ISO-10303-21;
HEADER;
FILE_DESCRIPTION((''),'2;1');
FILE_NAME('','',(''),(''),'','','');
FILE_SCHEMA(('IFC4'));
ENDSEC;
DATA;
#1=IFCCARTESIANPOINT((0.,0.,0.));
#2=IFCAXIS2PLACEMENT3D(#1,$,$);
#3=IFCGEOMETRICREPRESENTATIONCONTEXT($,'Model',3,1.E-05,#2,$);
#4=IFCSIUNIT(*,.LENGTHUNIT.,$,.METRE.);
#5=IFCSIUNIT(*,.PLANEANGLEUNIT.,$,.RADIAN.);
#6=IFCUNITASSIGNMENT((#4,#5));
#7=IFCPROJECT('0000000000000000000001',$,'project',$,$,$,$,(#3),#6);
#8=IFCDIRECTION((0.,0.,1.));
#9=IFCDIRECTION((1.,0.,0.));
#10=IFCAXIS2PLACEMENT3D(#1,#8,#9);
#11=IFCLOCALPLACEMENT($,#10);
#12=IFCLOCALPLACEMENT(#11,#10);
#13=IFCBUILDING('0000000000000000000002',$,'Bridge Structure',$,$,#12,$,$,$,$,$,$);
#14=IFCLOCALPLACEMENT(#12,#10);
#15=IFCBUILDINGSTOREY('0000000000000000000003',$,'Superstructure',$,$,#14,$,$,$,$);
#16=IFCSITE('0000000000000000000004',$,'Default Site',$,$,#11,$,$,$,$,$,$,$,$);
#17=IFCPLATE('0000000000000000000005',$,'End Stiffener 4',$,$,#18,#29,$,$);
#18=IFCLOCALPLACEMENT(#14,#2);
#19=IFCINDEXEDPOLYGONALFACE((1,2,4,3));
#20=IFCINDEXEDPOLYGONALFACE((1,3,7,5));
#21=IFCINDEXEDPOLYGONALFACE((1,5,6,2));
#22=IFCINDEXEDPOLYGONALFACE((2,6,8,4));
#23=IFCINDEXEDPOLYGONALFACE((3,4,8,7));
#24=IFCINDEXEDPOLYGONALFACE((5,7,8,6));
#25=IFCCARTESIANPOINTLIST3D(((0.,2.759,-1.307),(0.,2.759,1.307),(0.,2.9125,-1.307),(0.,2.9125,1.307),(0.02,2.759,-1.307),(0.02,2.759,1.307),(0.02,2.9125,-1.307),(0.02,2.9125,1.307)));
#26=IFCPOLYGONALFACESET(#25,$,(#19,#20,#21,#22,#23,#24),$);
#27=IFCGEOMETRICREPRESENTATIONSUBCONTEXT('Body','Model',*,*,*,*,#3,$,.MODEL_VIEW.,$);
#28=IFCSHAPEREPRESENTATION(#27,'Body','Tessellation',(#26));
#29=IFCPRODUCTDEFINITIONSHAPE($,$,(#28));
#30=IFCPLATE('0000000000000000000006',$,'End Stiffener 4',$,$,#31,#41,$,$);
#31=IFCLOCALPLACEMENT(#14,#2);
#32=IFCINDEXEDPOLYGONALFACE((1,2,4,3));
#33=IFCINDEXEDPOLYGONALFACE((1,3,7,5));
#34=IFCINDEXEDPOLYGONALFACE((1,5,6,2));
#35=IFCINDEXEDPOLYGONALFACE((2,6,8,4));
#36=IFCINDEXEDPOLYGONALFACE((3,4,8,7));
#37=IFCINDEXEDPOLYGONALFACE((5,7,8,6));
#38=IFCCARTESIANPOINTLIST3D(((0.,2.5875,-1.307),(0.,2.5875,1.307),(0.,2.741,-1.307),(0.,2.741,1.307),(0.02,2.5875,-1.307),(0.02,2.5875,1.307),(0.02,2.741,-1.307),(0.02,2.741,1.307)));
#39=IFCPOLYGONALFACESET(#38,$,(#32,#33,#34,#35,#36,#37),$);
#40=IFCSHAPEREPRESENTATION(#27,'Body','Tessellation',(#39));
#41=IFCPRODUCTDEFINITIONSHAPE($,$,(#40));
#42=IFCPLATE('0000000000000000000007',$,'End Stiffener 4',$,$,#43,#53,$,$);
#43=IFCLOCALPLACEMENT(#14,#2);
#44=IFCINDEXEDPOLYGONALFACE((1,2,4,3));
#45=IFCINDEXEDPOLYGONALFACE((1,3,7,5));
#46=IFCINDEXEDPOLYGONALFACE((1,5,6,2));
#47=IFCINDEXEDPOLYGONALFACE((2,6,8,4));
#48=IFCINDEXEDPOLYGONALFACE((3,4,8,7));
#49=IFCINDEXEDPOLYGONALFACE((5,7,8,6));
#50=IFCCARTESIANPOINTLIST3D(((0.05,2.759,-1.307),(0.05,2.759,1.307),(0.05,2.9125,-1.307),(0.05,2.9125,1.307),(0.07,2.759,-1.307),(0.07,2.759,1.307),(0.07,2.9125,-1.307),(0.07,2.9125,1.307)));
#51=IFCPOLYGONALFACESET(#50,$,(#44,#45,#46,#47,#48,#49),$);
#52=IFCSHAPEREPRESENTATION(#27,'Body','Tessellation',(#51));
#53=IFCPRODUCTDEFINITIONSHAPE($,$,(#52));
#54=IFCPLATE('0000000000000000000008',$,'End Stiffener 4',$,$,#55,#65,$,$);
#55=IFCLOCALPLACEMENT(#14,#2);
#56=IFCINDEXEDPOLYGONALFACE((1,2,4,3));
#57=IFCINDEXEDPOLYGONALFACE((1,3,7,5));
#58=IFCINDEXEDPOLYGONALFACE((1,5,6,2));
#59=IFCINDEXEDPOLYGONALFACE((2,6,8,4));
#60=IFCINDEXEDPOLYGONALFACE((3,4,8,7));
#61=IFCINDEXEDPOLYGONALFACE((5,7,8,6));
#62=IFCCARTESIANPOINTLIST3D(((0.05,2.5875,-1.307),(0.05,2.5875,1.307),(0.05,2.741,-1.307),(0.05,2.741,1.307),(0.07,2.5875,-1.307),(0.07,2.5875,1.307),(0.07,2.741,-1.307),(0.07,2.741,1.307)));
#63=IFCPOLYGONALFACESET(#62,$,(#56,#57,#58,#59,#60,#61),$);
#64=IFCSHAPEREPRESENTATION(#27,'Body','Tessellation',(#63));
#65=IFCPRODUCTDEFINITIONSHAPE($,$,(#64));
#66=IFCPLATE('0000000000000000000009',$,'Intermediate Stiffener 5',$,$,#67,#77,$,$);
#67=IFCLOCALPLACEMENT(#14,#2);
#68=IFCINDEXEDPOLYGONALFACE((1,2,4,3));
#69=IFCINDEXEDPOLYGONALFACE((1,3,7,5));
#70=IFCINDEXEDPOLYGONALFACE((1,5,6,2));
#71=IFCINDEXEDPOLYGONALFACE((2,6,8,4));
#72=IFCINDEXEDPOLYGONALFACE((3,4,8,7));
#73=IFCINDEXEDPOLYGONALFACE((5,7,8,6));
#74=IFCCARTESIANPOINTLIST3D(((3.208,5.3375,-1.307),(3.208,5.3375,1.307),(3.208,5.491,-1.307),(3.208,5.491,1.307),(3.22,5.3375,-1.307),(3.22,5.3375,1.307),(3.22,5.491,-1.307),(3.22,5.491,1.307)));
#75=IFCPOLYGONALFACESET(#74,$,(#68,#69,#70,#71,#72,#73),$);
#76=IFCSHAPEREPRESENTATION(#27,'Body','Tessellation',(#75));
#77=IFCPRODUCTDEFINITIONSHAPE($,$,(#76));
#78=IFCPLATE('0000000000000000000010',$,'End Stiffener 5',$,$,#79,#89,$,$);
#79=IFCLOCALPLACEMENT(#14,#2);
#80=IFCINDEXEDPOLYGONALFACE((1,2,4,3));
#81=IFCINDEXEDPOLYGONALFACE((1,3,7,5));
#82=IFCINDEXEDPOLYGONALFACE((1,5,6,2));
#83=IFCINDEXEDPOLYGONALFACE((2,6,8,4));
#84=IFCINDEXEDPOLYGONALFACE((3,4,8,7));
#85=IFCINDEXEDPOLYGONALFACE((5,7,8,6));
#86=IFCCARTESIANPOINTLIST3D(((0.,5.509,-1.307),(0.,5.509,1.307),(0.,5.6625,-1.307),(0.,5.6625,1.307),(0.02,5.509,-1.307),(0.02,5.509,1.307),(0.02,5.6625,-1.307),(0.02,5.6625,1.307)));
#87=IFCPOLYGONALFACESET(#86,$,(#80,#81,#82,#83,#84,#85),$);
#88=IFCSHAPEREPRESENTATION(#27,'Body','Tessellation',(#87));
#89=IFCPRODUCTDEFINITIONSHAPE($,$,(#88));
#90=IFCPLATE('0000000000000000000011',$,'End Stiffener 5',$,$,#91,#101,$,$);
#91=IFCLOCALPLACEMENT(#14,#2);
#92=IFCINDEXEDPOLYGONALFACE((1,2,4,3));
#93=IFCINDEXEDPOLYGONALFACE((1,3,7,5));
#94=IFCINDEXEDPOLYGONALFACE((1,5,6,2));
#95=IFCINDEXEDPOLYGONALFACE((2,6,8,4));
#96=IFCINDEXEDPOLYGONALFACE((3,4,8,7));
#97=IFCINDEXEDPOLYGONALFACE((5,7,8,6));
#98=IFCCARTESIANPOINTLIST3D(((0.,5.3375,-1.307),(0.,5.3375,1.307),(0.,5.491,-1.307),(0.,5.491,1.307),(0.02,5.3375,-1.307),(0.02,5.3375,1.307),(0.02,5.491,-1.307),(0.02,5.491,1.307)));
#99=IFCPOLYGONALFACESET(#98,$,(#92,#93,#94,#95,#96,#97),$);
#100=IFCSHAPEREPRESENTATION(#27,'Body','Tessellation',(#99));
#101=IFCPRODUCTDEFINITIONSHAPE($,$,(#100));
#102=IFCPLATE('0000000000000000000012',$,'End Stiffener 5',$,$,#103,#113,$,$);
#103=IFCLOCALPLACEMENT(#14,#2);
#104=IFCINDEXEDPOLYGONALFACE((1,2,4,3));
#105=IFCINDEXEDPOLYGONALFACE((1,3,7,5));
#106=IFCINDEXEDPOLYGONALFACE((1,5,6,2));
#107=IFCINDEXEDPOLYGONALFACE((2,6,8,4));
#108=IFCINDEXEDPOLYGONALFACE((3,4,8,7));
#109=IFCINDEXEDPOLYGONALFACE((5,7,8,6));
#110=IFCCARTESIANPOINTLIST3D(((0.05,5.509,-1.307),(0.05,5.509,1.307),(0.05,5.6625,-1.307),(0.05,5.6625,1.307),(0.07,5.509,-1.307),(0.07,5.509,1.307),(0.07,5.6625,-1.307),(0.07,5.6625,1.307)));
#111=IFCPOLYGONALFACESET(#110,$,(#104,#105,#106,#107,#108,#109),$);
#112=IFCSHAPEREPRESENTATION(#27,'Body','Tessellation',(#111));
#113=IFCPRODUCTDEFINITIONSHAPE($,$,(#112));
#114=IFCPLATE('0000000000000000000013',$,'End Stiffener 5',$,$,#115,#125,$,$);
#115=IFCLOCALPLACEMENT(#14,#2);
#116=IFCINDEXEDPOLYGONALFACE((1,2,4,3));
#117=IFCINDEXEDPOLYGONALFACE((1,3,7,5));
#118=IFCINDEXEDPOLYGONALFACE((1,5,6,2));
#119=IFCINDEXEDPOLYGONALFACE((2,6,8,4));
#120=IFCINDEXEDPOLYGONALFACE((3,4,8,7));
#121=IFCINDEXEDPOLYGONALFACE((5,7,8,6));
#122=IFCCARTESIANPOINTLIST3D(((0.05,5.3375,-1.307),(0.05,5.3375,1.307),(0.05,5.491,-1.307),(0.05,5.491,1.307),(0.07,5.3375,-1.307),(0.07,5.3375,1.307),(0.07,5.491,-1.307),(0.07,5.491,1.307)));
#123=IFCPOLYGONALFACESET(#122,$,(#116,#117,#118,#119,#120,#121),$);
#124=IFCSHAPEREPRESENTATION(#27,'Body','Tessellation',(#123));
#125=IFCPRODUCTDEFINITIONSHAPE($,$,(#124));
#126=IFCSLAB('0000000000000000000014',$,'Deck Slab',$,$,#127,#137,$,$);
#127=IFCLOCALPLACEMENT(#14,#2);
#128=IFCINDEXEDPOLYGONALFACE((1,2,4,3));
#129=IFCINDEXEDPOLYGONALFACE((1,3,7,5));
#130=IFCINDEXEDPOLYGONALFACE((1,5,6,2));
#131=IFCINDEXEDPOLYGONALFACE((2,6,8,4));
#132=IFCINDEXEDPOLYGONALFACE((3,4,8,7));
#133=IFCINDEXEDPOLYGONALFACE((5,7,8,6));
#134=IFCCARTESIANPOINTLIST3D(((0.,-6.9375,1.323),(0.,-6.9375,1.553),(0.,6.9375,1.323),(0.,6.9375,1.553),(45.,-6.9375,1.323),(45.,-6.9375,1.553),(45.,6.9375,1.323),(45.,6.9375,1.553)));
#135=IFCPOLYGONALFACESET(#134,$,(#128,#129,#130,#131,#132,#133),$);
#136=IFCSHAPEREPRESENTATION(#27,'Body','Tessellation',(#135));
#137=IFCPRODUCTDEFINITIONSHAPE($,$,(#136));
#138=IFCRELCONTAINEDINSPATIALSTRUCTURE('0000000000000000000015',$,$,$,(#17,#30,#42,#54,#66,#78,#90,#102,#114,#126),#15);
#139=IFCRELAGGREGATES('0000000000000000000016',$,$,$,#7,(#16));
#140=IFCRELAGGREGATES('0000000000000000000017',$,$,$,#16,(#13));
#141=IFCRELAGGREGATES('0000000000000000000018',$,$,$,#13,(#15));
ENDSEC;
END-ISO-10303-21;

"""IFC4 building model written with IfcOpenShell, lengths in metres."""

from ifc_helpers import new_model, si_unit, frame, origin, origin_with_axes, origin_2d_with_axis, place, context, subcontext, project, spatial, polyline, rectangle, outline, extrude, element, save


model = new_model("IFC4")

# Units and contexts
model_context = context("Model", 3, precision=1e-05, world=origin())
body_context = subcontext(model_context, "Body", "Model", "MODEL_VIEW")
ifc_project = project(units=[si_unit("LENGTHUNIT", "METRE"), si_unit("PLANEANGLEUNIT", "RADIAN")], contexts=[model_context])

# Site, building, storey
site_placement = place(None, origin_with_axes())
site = spatial("IfcSite", under=ifc_project, at=site_placement, Name="Default Site")
building_placement = place(site_placement, origin_with_axes())
building = spatial("IfcBuilding", under=site, at=building_placement, Name="Bridge Structure")
storey_placement = place(building_placement, origin_with_axes())
storey = spatial("IfcBuildingStorey", under=building, at=storey_placement, Name="Superstructure")

# Plates
for number, where, z_axis, x_axis, name in (
    (1, (0.01, 2.8357, -1.307), (0.0, 0.0, 1.0), (1.0, 0.0, 0.0), "End Stiffener 4"),
    (2, (0.01, 2.6643, -1.307), (0.0, 0.0, 1.0), (1.0, 0.0, 0.0), "End Stiffener 4"),
    (3, (0.06, 2.8357, -1.307), (0.0, 0.0, 1.0), (1.0, 0.0, 0.0), "End Stiffener 4"),
    (4, (0.06, 2.6643, -1.307), (0.0, 0.0, 1.0), (1.0, 0.0, 0.0), "End Stiffener 4"),
):
    element("IfcPlate", number, at=place(storey_placement, frame(where, z_axis=z_axis, x_axis=x_axis)), inside=storey, Name=name, context=body_context, shape_type="SweptSolid", body=[
        extrude(rectangle(XDim=0.02, YDim=0.1535, at=origin_2d_with_axis()), origin_with_axes(), (0.0, 0.0, 1.0), 2.614),
    ])
plate_1_placement = place(storey_placement, frame((3.214, 5.4143, -1.307), z_axis=(0.0, 0.0, 1.0), x_axis=(1.0, 0.0, 0.0)))
element("IfcPlate", 5, at=plate_1_placement, inside=storey, Name="Intermediate Stiffener 5", context=body_context, shape_type="SweptSolid", body=[
    extrude(rectangle(XDim=0.012, YDim=0.1535, at=origin_2d_with_axis()), origin_with_axes(), (0.0, 0.0, 1.0), 2.614),
])
for number, where, z_axis, x_axis, name in (
    (6, (0.01, 5.5857, -1.307), (0.0, 0.0, 1.0), (1.0, 0.0, 0.0), "End Stiffener 5"),
    (7, (0.01, 5.4143, -1.307), (0.0, 0.0, 1.0), (1.0, 0.0, 0.0), "End Stiffener 5"),
    (8, (0.06, 5.5857, -1.307), (0.0, 0.0, 1.0), (1.0, 0.0, 0.0), "End Stiffener 5"),
    (9, (0.06, 5.4143, -1.307), (0.0, 0.0, 1.0), (1.0, 0.0, 0.0), "End Stiffener 5"),
):
    element("IfcPlate", number, at=place(storey_placement, frame(where, z_axis=z_axis, x_axis=x_axis)), inside=storey, Name=name, context=body_context, shape_type="SweptSolid", body=[
        extrude(rectangle(XDim=0.02, YDim=0.1535, at=origin_2d_with_axis()), origin_with_axes(), (0.0, 0.0, 1.0), 2.614),
    ])

# Slab
slab_placement = place(storey_placement, frame((0.0, 0.0, 1.323), z_axis=(0.0, 0.0, 1.0), x_axis=(1.0, 0.0, 0.0)))
element("IfcSlab", 10, at=slab_placement, inside=storey, Name="Deck Slab", context=body_context, shape_type="SweptSolid", body=[
    extrude(outline(polyline([(0.0, -6.9375), (45.0, -6.9375), (45.0, 6.9375), (0.0, 6.9375), (0.0, -6.9375)])), origin_with_axes(), (0.0, 0.0, 1.0), 0.23),
])

save(model, "model.ifc")
